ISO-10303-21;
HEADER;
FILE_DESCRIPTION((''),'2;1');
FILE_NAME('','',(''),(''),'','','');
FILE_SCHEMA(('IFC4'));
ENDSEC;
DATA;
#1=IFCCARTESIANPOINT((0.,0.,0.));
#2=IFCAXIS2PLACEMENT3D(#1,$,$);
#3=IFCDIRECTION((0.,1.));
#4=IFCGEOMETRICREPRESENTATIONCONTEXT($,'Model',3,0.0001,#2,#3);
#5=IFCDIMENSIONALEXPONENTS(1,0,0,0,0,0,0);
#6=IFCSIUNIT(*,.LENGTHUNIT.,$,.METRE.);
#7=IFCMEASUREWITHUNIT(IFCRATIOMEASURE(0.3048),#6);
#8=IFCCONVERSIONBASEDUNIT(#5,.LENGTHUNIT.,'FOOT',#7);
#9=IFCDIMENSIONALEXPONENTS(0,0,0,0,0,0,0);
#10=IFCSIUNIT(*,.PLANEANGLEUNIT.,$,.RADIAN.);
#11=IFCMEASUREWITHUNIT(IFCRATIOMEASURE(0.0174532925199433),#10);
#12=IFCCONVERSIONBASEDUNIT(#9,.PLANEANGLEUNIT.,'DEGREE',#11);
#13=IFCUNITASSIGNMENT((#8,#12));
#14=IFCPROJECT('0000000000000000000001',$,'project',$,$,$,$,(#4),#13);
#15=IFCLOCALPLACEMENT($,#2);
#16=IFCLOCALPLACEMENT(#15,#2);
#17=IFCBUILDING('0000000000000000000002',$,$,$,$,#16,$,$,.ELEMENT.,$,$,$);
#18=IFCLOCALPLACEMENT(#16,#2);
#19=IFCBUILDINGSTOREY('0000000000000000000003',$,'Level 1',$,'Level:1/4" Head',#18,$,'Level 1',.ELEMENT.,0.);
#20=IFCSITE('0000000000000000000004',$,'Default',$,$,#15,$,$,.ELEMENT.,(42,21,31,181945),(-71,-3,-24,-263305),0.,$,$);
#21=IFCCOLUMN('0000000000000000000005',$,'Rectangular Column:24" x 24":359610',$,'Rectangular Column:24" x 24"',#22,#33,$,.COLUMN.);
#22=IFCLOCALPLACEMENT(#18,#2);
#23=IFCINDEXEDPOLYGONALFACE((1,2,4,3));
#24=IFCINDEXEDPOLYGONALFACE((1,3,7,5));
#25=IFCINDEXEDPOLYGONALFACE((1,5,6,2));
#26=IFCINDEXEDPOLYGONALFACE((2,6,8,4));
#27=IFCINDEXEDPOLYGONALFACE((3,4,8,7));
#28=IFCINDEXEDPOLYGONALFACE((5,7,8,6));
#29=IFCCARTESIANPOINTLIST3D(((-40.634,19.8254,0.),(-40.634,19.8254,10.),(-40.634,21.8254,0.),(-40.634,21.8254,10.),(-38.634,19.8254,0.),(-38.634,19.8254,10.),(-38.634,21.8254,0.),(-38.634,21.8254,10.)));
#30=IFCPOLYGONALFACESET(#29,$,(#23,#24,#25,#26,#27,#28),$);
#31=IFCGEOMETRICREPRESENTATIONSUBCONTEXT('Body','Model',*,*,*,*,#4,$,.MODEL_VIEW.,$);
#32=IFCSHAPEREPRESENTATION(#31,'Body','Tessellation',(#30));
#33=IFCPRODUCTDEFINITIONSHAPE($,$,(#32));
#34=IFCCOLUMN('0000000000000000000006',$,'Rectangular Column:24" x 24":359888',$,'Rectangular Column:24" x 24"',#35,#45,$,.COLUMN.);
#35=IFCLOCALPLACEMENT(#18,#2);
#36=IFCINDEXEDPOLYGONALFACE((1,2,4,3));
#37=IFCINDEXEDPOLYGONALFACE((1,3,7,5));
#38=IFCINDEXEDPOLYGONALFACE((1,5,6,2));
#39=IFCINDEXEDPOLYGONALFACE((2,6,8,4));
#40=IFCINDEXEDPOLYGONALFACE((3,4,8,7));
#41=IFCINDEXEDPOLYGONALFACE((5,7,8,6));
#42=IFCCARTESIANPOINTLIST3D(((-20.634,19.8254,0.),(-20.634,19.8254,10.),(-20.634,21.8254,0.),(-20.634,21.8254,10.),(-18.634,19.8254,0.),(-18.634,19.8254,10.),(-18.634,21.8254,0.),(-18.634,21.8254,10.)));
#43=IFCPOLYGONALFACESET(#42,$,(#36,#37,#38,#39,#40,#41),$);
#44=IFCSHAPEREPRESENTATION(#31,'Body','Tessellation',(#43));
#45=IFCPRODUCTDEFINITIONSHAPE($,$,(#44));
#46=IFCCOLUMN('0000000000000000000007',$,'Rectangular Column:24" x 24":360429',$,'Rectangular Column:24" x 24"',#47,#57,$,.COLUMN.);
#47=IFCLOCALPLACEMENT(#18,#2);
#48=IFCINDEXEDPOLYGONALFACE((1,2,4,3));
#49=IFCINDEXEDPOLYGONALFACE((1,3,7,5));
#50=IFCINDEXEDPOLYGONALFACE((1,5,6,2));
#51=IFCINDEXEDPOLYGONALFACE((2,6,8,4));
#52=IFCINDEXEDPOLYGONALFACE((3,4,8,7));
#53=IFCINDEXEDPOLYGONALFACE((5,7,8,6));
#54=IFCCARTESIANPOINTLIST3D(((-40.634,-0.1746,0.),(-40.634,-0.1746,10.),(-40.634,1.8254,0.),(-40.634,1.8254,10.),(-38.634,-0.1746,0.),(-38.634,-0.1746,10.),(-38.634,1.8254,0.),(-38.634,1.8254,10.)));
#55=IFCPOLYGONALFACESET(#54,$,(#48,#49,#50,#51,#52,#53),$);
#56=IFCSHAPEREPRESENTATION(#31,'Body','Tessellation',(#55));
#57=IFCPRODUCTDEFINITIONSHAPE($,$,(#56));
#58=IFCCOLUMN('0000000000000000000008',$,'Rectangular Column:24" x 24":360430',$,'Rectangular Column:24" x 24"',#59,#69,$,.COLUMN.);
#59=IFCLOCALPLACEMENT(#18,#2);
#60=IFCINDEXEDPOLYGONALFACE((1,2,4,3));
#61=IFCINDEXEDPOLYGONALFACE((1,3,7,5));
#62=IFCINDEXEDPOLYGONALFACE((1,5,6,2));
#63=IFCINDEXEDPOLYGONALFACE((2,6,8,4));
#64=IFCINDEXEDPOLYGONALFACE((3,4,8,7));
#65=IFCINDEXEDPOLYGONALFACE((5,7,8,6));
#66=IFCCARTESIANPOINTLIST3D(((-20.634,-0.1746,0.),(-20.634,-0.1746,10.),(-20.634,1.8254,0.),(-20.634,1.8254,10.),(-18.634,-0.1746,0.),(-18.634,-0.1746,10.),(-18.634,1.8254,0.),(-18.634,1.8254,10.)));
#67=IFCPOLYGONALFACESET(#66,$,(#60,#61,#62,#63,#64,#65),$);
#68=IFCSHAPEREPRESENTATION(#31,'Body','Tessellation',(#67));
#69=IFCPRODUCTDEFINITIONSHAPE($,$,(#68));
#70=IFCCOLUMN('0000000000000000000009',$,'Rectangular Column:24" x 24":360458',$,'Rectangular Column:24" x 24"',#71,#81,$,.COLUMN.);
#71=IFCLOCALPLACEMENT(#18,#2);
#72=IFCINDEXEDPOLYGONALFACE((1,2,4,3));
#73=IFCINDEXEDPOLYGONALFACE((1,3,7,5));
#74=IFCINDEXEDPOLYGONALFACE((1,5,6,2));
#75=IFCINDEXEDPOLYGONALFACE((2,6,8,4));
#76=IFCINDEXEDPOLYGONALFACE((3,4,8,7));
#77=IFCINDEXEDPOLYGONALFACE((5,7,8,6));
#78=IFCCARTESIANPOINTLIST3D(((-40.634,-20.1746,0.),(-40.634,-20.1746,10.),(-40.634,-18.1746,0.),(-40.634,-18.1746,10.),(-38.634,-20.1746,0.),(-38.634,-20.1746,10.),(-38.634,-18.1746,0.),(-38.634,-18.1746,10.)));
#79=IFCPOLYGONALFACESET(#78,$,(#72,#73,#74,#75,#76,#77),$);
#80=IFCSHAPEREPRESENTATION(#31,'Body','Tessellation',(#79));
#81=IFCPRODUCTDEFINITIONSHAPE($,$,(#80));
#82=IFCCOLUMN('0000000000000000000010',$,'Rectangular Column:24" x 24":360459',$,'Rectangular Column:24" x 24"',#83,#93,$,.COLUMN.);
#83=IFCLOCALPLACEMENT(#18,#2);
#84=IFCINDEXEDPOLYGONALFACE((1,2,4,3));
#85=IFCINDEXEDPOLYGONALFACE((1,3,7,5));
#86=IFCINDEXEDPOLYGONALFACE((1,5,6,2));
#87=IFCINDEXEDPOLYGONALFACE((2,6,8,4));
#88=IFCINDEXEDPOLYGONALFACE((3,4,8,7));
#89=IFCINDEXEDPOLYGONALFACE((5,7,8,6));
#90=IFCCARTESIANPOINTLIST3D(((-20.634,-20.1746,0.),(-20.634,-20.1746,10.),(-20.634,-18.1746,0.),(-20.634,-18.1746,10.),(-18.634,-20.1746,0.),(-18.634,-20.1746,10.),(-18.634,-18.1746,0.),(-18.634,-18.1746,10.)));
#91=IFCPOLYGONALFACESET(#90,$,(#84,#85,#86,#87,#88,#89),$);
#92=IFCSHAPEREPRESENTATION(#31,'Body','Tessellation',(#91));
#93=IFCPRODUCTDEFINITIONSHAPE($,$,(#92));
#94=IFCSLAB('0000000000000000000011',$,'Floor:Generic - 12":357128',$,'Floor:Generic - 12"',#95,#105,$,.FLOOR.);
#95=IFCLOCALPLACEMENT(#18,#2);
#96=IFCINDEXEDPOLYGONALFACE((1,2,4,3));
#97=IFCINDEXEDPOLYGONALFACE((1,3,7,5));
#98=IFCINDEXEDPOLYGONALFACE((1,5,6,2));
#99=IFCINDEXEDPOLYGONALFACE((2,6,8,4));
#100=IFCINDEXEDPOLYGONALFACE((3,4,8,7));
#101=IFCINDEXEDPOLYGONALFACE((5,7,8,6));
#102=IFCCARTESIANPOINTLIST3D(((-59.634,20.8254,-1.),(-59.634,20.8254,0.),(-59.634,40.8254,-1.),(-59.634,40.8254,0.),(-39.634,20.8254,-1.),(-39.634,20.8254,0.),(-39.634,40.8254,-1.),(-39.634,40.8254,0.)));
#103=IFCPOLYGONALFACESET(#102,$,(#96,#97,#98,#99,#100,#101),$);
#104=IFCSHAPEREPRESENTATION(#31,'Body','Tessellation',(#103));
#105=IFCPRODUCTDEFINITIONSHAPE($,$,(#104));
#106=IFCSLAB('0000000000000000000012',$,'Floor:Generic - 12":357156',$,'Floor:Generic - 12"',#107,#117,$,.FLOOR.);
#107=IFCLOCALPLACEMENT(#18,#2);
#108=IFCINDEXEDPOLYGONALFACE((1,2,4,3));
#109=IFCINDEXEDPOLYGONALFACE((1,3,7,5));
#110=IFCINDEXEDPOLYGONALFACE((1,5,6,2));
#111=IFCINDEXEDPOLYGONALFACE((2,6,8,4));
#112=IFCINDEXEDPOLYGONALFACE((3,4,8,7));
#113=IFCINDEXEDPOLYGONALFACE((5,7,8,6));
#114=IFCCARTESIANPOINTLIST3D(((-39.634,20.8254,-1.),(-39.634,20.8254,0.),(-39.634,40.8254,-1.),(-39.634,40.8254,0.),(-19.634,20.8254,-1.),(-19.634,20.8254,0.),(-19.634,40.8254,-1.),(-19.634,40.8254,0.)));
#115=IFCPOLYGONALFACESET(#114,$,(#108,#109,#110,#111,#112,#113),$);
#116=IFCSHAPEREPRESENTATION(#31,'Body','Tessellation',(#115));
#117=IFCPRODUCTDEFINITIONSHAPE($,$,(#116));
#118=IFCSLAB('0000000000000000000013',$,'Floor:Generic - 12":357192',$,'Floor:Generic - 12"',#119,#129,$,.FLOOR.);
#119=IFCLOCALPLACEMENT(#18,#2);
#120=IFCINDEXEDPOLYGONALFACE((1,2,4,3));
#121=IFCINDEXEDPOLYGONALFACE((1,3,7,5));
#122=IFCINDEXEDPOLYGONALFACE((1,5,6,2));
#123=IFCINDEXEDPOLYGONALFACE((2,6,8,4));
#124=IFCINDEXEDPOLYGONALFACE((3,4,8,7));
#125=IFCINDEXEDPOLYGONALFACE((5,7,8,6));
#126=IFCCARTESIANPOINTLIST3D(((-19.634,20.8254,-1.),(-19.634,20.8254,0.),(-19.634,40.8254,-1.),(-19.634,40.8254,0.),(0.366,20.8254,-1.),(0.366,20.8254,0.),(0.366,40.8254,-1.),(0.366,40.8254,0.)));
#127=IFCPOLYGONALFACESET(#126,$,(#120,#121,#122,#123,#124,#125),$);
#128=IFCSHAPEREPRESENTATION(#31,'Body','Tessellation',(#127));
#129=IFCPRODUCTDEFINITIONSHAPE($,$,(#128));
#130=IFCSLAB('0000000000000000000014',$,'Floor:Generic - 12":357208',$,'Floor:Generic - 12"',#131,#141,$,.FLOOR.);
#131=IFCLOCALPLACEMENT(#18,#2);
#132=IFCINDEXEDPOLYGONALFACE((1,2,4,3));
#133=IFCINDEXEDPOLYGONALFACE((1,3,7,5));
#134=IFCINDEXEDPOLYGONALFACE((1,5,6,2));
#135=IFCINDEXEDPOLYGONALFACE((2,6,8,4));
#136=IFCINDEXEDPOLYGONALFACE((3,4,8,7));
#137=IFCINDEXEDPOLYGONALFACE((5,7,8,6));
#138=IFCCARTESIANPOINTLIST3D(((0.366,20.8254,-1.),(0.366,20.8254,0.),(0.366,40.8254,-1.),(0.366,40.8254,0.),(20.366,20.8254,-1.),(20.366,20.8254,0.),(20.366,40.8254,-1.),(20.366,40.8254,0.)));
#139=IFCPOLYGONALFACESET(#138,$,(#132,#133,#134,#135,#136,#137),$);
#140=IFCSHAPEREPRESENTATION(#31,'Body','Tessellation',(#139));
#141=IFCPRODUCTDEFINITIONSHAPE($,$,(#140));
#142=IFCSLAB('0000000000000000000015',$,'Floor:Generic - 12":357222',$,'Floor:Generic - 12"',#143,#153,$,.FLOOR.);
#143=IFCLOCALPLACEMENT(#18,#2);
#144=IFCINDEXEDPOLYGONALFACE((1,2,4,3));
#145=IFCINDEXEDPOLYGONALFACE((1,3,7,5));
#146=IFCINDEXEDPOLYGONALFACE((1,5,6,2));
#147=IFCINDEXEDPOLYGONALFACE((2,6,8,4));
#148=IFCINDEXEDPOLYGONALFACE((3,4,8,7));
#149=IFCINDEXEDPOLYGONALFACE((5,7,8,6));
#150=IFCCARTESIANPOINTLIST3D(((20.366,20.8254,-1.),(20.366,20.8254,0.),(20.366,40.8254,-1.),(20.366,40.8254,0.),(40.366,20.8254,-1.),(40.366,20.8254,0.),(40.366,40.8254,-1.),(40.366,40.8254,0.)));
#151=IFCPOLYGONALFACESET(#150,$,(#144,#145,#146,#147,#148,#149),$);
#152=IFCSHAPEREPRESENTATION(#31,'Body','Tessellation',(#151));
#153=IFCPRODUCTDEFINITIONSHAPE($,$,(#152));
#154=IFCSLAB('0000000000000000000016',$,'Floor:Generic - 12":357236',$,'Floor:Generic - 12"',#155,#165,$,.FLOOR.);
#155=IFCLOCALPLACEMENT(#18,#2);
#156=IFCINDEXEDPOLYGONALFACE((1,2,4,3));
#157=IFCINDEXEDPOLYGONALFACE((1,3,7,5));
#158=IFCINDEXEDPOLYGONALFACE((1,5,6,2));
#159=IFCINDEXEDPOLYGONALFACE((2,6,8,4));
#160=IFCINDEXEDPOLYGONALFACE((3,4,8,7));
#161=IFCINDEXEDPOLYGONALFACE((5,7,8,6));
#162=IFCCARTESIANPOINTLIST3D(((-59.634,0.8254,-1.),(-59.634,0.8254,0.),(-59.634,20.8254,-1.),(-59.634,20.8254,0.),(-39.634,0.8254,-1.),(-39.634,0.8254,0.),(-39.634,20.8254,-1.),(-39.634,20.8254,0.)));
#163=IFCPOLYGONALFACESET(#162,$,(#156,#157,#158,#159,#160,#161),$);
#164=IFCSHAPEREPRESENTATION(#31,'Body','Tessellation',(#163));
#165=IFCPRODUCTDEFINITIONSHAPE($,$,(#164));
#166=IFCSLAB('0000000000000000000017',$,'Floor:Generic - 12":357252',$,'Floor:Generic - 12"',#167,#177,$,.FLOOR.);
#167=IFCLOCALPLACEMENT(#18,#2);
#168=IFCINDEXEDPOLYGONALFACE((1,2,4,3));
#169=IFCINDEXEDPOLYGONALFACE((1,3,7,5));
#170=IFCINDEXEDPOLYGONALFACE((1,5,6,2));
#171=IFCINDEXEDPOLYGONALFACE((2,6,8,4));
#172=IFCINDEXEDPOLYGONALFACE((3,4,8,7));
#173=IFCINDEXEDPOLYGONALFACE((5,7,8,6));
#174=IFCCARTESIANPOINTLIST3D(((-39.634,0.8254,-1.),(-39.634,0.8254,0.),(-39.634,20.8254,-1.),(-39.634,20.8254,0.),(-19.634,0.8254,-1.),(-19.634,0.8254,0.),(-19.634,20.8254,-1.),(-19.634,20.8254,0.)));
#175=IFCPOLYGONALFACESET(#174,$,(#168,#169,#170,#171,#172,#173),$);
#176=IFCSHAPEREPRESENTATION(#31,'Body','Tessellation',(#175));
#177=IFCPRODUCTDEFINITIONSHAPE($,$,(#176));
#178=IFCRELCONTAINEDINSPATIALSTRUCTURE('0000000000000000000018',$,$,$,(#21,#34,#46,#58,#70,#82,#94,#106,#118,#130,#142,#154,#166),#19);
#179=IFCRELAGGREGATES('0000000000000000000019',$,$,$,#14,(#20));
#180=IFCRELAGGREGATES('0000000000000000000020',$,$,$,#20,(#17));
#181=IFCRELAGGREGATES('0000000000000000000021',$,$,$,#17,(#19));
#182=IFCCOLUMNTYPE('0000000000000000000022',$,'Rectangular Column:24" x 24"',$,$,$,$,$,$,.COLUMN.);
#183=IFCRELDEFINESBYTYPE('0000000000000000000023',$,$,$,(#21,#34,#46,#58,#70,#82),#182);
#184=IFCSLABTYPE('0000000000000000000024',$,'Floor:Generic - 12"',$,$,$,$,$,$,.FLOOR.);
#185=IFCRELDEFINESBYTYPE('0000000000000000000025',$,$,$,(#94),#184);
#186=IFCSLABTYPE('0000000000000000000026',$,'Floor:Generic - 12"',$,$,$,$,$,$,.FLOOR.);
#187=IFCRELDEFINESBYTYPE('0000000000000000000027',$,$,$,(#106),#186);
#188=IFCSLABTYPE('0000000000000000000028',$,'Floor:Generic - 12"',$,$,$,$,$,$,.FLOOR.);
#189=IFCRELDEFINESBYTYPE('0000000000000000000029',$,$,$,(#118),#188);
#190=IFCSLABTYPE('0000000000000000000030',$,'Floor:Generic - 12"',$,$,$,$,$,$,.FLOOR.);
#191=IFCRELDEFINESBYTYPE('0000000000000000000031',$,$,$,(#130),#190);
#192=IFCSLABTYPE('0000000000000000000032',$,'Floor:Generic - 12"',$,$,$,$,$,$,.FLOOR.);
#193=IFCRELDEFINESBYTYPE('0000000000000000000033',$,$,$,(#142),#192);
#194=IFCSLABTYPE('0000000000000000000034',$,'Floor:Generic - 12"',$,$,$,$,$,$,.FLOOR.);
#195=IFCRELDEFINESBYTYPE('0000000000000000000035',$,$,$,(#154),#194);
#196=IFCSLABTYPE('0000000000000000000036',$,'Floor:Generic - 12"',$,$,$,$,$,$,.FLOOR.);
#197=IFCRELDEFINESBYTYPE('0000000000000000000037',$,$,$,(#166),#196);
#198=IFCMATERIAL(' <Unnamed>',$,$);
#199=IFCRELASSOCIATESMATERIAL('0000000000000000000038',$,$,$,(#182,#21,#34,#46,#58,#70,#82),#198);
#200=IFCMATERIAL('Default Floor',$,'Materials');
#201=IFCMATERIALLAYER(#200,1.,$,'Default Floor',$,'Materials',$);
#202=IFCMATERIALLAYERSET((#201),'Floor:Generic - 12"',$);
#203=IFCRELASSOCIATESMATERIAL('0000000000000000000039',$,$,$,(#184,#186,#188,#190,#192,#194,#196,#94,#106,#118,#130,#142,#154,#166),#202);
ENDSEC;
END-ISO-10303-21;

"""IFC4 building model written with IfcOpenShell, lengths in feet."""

from ifc_helpers import new_model, entity, si_unit, converted_unit, direction, frame, frame_2d, origin, origin_2d_with_axis, place, context, subcontext, project, spatial, rectangle, extrude, source, transform, mapped, material, layer, layer_set, layer_usage, material_profile, profile_set, profile_usage, type_object, type_shapes, element, save


model = new_model("IFC4")

# Units and contexts
model_context = context("Model", 3, precision=0.0001, world=origin(), true_north=direction((0.0, 1.0)))
body_context = subcontext(model_context, "Body", "Model", "MODEL_VIEW")
ifc_project = project(units=[converted_unit("LENGTHUNIT", "FOOT", entity("IfcRatioMeasure", 0.3048), si_unit("LENGTHUNIT", "METRE"), dimensions=[1, 0, 0, 0, 0, 0, 0]), converted_unit("PLANEANGLEUNIT", "DEGREE", entity("IfcRatioMeasure", 0.0174532925199433), si_unit("PLANEANGLEUNIT", "RADIAN"), dimensions=[0, 0, 0, 0, 0, 0, 0])], contexts=[model_context])

# Site, building, storey
site_placement = place(None, origin())
site = spatial("IfcSite", under=ifc_project, at=site_placement, Name="Default", CompositionType="ELEMENT", RefLatitude=(42, 21, 31, 181945), RefLongitude=(-71, -3, -24, -263305), RefElevation=0.0)
building_placement = place(site_placement, origin())
building = spatial("IfcBuilding", under=site, at=building_placement, CompositionType="ELEMENT")
storey_placement = place(building_placement, origin())
storey = spatial("IfcBuildingStorey", under=building, at=storey_placement, Name="Level 1", ObjectType="Level:1/4\" Head", LongName="Level 1", CompositionType="ELEMENT", Elevation=0.0)

# Columns
ifc_material_1 = material(Name=" <Unnamed>")
ifc_material_profile = material_profile(ifc_material_1, rectangle(XDim=2.0, YDim=2.0, at=origin_2d_with_axis()), Name="24\" x 24\"")
ifc_profile_set = profile_set([ifc_material_profile], Name="24\" x 24\"")
ifc_profile_usage_1 = profile_usage(ifc_profile_set)
column_type = type_object("IfcColumnType", Name="Rectangular Column:24\" x 24\"", PredefinedType="COLUMN", material=ifc_profile_set)
shared_shape = source(origin(), body_context, "Body", "SweptSolid", [
    extrude(rectangle(XDim=2.0, YDim=2.0, at=origin_2d_with_axis()), frame((0.0, 0.0, 0.0), z_axis=(0.0, 0.0, 1.0), x_axis=(0.0, -1.0, 0.0)), (0.0, 0.0, 1.0), 10.0),
])
type_shapes(column_type, [shared_shape])
column_1_placement = place(storey_placement, frame((-39.634, 20.8254, 0.0)))
element("IfcColumn", 1, at=column_1_placement, inside=storey, type_object=column_type, material=ifc_profile_usage_1, Name="Rectangular Column:24\" x 24\":359610", ObjectType="Rectangular Column:24\" x 24\"", PredefinedType="COLUMN", context=body_context, shape_type="MappedRepresentation", body=[
    mapped(shared_shape, transform((0.0, 0.0, 0.0), scale=1.0)),
])
ifc_profile_usage_2 = profile_usage(ifc_profile_set)
column_2_placement = place(storey_placement, frame((-19.634, 20.8254, 0.0)))
element("IfcColumn", 2, at=column_2_placement, inside=storey, type_object=column_type, material=ifc_profile_usage_2, Name="Rectangular Column:24\" x 24\":359888", ObjectType="Rectangular Column:24\" x 24\"", PredefinedType="COLUMN", context=body_context, shape_type="MappedRepresentation", body=[
    mapped(shared_shape, transform((0.0, 0.0, 0.0), scale=1.0)),
])
ifc_profile_usage_3 = profile_usage(ifc_profile_set)
column_3_placement = place(storey_placement, frame((-39.634, 0.8254, 0.0)))
element("IfcColumn", 3, at=column_3_placement, inside=storey, type_object=column_type, material=ifc_profile_usage_3, Name="Rectangular Column:24\" x 24\":360429", ObjectType="Rectangular Column:24\" x 24\"", PredefinedType="COLUMN", context=body_context, shape_type="MappedRepresentation", body=[
    mapped(shared_shape, transform((0.0, 0.0, 0.0), scale=1.0)),
])
ifc_profile_usage_4 = profile_usage(ifc_profile_set)
column_4_placement = place(storey_placement, frame((-19.634, 0.8254, 0.0)))
element("IfcColumn", 4, at=column_4_placement, inside=storey, type_object=column_type, material=ifc_profile_usage_4, Name="Rectangular Column:24\" x 24\":360430", ObjectType="Rectangular Column:24\" x 24\"", PredefinedType="COLUMN", context=body_context, shape_type="MappedRepresentation", body=[
    mapped(shared_shape, transform((0.0, 0.0, 0.0), scale=1.0)),
])
ifc_profile_usage_5 = profile_usage(ifc_profile_set)
column_5_placement = place(storey_placement, frame((-39.634, -19.1746, 0.0)))
element("IfcColumn", 5, at=column_5_placement, inside=storey, type_object=column_type, material=ifc_profile_usage_5, Name="Rectangular Column:24\" x 24\":360458", ObjectType="Rectangular Column:24\" x 24\"", PredefinedType="COLUMN", context=body_context, shape_type="MappedRepresentation", body=[
    mapped(shared_shape, transform((0.0, 0.0, 0.0), scale=1.0)),
])
ifc_profile_usage_6 = profile_usage(ifc_profile_set)
column_6_placement = place(storey_placement, frame((-19.634, -19.1746, 0.0)))
element("IfcColumn", 6, at=column_6_placement, inside=storey, type_object=column_type, material=ifc_profile_usage_6, Name="Rectangular Column:24\" x 24\":360459", ObjectType="Rectangular Column:24\" x 24\"", PredefinedType="COLUMN", context=body_context, shape_type="MappedRepresentation", body=[
    mapped(shared_shape, transform((0.0, 0.0, 0.0), scale=1.0)),
])

# Slabs
ifc_material_2 = material(Name="Default Floor", Category="Materials")
ifc_layer_1 = layer(ifc_material_2, 1.0, Name="Default Floor", Category="Materials")
ifc_layer_set_1 = layer_set([ifc_layer_1], Name="Floor:Generic - 12\"")
ifc_layer_usage_1 = layer_usage(ifc_layer_set_1, "AXIS3", "POSITIVE", 0.0)
slab_type_1 = type_object("IfcSlabType", Name="Floor:Generic - 12\"", PredefinedType="FLOOR", material=ifc_layer_set_1)
slab_1_placement = place(storey_placement, origin())
element("IfcSlab", 7, at=slab_1_placement, inside=storey, type_object=slab_type_1, material=ifc_layer_usage_1, Name="Floor:Generic - 12\":357128", ObjectType="Floor:Generic - 12\"", PredefinedType="FLOOR", context=body_context, shape_type="SweptSolid", body=[
    extrude(rectangle(XDim=20.0, YDim=20.0, at=frame_2d((0.0, 0.0), x_axis=(1.0, 0.0))), frame((-49.634, 30.8254, 0.0), z_axis=(0.0, 0.0, -1.0), x_axis=(0.0, 1.0, 0.0)), (0.0, 0.0, 1.0), 1.0),
])
ifc_layer_usage_2 = layer_usage(ifc_layer_set_1, "AXIS3", "POSITIVE", 0.0)
slab_type_2 = type_object("IfcSlabType", Name="Floor:Generic - 12\"", PredefinedType="FLOOR", material=ifc_layer_set_1)
slab_2_placement = place(storey_placement, origin())
element("IfcSlab", 8, at=slab_2_placement, inside=storey, type_object=slab_type_2, material=ifc_layer_usage_2, Name="Floor:Generic - 12\":357156", ObjectType="Floor:Generic - 12\"", PredefinedType="FLOOR", context=body_context, shape_type="SweptSolid", body=[
    extrude(rectangle(XDim=20.0, YDim=20.0, at=origin_2d_with_axis()), frame((-29.634, 30.8254, 0.0), z_axis=(0.0, 0.0, -1.0), x_axis=(0.0, 1.0, 0.0)), (0.0, 0.0, 1.0), 1.0),
])
ifc_layer_usage_3 = layer_usage(ifc_layer_set_1, "AXIS3", "POSITIVE", 0.0)
slab_type_3 = type_object("IfcSlabType", Name="Floor:Generic - 12\"", PredefinedType="FLOOR", material=ifc_layer_set_1)
slab_3_placement = place(storey_placement, origin())
element("IfcSlab", 9, at=slab_3_placement, inside=storey, type_object=slab_type_3, material=ifc_layer_usage_3, Name="Floor:Generic - 12\":357192", ObjectType="Floor:Generic - 12\"", PredefinedType="FLOOR", context=body_context, shape_type="SweptSolid", body=[
    extrude(rectangle(XDim=20.0, YDim=20.0, at=origin_2d_with_axis()), frame((-9.634, 30.8254, 0.0), z_axis=(0.0, 0.0, -1.0), x_axis=(0.0, 1.0, 0.0)), (0.0, 0.0, 1.0), 1.0),
])
ifc_layer_usage_4 = layer_usage(ifc_layer_set_1, "AXIS3", "POSITIVE", 0.0)
slab_type_4 = type_object("IfcSlabType", Name="Floor:Generic - 12\"", PredefinedType="FLOOR", material=ifc_layer_set_1)
slab_4_placement = place(storey_placement, origin())
element("IfcSlab", 10, at=slab_4_placement, inside=storey, type_object=slab_type_4, material=ifc_layer_usage_4, Name="Floor:Generic - 12\":357208", ObjectType="Floor:Generic - 12\"", PredefinedType="FLOOR", context=body_context, shape_type="SweptSolid", body=[
    extrude(rectangle(XDim=20.0, YDim=20.0, at=origin_2d_with_axis()), frame((10.366, 30.8254, 0.0), z_axis=(0.0, 0.0, -1.0), x_axis=(0.0, 1.0, 0.0)), (0.0, 0.0, 1.0), 1.0),
])
ifc_layer_usage_5 = layer_usage(ifc_layer_set_1, "AXIS3", "POSITIVE", 0.0)
slab_type_5 = type_object("IfcSlabType", Name="Floor:Generic - 12\"", PredefinedType="FLOOR", material=ifc_layer_set_1)
slab_5_placement = place(storey_placement, origin())
element("IfcSlab", 11, at=slab_5_placement, inside=storey, type_object=slab_type_5, material=ifc_layer_usage_5, Name="Floor:Generic - 12\":357222", ObjectType="Floor:Generic - 12\"", PredefinedType="FLOOR", context=body_context, shape_type="SweptSolid", body=[
    extrude(rectangle(XDim=20.0, YDim=20.0, at=frame_2d((0.0, 0.0), x_axis=(1.0, 0.0))), frame((30.366, 30.8254, 0.0), z_axis=(0.0, 0.0, -1.0), x_axis=(0.0, 1.0, 0.0)), (0.0, 0.0, 1.0), 1.0),
])
ifc_layer_usage_6 = layer_usage(ifc_layer_set_1, "AXIS3", "POSITIVE", 0.0)
slab_type_6 = type_object("IfcSlabType", Name="Floor:Generic - 12\"", PredefinedType="FLOOR", material=ifc_layer_set_1)
slab_6_placement = place(storey_placement, origin())
element("IfcSlab", 12, at=slab_6_placement, inside=storey, type_object=slab_type_6, material=ifc_layer_usage_6, Name="Floor:Generic - 12\":357236", ObjectType="Floor:Generic - 12\"", PredefinedType="FLOOR", context=body_context, shape_type="SweptSolid", body=[
    extrude(rectangle(XDim=20.0, YDim=20.0, at=frame_2d((0.0, 0.0), x_axis=(1.0, 0.0))), frame((-49.634, 10.8254, 0.0), z_axis=(0.0, 0.0, -1.0), x_axis=(0.0, 1.0, 0.0)), (0.0, 0.0, 1.0), 1.0),
])
ifc_layer_usage_7 = layer_usage(ifc_layer_set_1, "AXIS3", "POSITIVE", 0.0)
slab_type_7 = type_object("IfcSlabType", Name="Floor:Generic - 12\"", PredefinedType="FLOOR", material=ifc_layer_set_1)
slab_7_placement = place(storey_placement, origin())
element("IfcSlab", 13, at=slab_7_placement, inside=storey, type_object=slab_type_7, material=ifc_layer_usage_7, Name="Floor:Generic - 12\":357252", ObjectType="Floor:Generic - 12\"", PredefinedType="FLOOR", context=body_context, shape_type="SweptSolid", body=[
    extrude(rectangle(XDim=20.0, YDim=20.0, at=frame_2d((0.0, 0.0), x_axis=(1.0, 0.0))), frame((-29.634, 10.8254, 0.0), z_axis=(0.0, 0.0, -1.0), x_axis=(0.0, 1.0, 0.0)), (0.0, 0.0, 1.0), 1.0),
])

save(model, "model.ifc")
